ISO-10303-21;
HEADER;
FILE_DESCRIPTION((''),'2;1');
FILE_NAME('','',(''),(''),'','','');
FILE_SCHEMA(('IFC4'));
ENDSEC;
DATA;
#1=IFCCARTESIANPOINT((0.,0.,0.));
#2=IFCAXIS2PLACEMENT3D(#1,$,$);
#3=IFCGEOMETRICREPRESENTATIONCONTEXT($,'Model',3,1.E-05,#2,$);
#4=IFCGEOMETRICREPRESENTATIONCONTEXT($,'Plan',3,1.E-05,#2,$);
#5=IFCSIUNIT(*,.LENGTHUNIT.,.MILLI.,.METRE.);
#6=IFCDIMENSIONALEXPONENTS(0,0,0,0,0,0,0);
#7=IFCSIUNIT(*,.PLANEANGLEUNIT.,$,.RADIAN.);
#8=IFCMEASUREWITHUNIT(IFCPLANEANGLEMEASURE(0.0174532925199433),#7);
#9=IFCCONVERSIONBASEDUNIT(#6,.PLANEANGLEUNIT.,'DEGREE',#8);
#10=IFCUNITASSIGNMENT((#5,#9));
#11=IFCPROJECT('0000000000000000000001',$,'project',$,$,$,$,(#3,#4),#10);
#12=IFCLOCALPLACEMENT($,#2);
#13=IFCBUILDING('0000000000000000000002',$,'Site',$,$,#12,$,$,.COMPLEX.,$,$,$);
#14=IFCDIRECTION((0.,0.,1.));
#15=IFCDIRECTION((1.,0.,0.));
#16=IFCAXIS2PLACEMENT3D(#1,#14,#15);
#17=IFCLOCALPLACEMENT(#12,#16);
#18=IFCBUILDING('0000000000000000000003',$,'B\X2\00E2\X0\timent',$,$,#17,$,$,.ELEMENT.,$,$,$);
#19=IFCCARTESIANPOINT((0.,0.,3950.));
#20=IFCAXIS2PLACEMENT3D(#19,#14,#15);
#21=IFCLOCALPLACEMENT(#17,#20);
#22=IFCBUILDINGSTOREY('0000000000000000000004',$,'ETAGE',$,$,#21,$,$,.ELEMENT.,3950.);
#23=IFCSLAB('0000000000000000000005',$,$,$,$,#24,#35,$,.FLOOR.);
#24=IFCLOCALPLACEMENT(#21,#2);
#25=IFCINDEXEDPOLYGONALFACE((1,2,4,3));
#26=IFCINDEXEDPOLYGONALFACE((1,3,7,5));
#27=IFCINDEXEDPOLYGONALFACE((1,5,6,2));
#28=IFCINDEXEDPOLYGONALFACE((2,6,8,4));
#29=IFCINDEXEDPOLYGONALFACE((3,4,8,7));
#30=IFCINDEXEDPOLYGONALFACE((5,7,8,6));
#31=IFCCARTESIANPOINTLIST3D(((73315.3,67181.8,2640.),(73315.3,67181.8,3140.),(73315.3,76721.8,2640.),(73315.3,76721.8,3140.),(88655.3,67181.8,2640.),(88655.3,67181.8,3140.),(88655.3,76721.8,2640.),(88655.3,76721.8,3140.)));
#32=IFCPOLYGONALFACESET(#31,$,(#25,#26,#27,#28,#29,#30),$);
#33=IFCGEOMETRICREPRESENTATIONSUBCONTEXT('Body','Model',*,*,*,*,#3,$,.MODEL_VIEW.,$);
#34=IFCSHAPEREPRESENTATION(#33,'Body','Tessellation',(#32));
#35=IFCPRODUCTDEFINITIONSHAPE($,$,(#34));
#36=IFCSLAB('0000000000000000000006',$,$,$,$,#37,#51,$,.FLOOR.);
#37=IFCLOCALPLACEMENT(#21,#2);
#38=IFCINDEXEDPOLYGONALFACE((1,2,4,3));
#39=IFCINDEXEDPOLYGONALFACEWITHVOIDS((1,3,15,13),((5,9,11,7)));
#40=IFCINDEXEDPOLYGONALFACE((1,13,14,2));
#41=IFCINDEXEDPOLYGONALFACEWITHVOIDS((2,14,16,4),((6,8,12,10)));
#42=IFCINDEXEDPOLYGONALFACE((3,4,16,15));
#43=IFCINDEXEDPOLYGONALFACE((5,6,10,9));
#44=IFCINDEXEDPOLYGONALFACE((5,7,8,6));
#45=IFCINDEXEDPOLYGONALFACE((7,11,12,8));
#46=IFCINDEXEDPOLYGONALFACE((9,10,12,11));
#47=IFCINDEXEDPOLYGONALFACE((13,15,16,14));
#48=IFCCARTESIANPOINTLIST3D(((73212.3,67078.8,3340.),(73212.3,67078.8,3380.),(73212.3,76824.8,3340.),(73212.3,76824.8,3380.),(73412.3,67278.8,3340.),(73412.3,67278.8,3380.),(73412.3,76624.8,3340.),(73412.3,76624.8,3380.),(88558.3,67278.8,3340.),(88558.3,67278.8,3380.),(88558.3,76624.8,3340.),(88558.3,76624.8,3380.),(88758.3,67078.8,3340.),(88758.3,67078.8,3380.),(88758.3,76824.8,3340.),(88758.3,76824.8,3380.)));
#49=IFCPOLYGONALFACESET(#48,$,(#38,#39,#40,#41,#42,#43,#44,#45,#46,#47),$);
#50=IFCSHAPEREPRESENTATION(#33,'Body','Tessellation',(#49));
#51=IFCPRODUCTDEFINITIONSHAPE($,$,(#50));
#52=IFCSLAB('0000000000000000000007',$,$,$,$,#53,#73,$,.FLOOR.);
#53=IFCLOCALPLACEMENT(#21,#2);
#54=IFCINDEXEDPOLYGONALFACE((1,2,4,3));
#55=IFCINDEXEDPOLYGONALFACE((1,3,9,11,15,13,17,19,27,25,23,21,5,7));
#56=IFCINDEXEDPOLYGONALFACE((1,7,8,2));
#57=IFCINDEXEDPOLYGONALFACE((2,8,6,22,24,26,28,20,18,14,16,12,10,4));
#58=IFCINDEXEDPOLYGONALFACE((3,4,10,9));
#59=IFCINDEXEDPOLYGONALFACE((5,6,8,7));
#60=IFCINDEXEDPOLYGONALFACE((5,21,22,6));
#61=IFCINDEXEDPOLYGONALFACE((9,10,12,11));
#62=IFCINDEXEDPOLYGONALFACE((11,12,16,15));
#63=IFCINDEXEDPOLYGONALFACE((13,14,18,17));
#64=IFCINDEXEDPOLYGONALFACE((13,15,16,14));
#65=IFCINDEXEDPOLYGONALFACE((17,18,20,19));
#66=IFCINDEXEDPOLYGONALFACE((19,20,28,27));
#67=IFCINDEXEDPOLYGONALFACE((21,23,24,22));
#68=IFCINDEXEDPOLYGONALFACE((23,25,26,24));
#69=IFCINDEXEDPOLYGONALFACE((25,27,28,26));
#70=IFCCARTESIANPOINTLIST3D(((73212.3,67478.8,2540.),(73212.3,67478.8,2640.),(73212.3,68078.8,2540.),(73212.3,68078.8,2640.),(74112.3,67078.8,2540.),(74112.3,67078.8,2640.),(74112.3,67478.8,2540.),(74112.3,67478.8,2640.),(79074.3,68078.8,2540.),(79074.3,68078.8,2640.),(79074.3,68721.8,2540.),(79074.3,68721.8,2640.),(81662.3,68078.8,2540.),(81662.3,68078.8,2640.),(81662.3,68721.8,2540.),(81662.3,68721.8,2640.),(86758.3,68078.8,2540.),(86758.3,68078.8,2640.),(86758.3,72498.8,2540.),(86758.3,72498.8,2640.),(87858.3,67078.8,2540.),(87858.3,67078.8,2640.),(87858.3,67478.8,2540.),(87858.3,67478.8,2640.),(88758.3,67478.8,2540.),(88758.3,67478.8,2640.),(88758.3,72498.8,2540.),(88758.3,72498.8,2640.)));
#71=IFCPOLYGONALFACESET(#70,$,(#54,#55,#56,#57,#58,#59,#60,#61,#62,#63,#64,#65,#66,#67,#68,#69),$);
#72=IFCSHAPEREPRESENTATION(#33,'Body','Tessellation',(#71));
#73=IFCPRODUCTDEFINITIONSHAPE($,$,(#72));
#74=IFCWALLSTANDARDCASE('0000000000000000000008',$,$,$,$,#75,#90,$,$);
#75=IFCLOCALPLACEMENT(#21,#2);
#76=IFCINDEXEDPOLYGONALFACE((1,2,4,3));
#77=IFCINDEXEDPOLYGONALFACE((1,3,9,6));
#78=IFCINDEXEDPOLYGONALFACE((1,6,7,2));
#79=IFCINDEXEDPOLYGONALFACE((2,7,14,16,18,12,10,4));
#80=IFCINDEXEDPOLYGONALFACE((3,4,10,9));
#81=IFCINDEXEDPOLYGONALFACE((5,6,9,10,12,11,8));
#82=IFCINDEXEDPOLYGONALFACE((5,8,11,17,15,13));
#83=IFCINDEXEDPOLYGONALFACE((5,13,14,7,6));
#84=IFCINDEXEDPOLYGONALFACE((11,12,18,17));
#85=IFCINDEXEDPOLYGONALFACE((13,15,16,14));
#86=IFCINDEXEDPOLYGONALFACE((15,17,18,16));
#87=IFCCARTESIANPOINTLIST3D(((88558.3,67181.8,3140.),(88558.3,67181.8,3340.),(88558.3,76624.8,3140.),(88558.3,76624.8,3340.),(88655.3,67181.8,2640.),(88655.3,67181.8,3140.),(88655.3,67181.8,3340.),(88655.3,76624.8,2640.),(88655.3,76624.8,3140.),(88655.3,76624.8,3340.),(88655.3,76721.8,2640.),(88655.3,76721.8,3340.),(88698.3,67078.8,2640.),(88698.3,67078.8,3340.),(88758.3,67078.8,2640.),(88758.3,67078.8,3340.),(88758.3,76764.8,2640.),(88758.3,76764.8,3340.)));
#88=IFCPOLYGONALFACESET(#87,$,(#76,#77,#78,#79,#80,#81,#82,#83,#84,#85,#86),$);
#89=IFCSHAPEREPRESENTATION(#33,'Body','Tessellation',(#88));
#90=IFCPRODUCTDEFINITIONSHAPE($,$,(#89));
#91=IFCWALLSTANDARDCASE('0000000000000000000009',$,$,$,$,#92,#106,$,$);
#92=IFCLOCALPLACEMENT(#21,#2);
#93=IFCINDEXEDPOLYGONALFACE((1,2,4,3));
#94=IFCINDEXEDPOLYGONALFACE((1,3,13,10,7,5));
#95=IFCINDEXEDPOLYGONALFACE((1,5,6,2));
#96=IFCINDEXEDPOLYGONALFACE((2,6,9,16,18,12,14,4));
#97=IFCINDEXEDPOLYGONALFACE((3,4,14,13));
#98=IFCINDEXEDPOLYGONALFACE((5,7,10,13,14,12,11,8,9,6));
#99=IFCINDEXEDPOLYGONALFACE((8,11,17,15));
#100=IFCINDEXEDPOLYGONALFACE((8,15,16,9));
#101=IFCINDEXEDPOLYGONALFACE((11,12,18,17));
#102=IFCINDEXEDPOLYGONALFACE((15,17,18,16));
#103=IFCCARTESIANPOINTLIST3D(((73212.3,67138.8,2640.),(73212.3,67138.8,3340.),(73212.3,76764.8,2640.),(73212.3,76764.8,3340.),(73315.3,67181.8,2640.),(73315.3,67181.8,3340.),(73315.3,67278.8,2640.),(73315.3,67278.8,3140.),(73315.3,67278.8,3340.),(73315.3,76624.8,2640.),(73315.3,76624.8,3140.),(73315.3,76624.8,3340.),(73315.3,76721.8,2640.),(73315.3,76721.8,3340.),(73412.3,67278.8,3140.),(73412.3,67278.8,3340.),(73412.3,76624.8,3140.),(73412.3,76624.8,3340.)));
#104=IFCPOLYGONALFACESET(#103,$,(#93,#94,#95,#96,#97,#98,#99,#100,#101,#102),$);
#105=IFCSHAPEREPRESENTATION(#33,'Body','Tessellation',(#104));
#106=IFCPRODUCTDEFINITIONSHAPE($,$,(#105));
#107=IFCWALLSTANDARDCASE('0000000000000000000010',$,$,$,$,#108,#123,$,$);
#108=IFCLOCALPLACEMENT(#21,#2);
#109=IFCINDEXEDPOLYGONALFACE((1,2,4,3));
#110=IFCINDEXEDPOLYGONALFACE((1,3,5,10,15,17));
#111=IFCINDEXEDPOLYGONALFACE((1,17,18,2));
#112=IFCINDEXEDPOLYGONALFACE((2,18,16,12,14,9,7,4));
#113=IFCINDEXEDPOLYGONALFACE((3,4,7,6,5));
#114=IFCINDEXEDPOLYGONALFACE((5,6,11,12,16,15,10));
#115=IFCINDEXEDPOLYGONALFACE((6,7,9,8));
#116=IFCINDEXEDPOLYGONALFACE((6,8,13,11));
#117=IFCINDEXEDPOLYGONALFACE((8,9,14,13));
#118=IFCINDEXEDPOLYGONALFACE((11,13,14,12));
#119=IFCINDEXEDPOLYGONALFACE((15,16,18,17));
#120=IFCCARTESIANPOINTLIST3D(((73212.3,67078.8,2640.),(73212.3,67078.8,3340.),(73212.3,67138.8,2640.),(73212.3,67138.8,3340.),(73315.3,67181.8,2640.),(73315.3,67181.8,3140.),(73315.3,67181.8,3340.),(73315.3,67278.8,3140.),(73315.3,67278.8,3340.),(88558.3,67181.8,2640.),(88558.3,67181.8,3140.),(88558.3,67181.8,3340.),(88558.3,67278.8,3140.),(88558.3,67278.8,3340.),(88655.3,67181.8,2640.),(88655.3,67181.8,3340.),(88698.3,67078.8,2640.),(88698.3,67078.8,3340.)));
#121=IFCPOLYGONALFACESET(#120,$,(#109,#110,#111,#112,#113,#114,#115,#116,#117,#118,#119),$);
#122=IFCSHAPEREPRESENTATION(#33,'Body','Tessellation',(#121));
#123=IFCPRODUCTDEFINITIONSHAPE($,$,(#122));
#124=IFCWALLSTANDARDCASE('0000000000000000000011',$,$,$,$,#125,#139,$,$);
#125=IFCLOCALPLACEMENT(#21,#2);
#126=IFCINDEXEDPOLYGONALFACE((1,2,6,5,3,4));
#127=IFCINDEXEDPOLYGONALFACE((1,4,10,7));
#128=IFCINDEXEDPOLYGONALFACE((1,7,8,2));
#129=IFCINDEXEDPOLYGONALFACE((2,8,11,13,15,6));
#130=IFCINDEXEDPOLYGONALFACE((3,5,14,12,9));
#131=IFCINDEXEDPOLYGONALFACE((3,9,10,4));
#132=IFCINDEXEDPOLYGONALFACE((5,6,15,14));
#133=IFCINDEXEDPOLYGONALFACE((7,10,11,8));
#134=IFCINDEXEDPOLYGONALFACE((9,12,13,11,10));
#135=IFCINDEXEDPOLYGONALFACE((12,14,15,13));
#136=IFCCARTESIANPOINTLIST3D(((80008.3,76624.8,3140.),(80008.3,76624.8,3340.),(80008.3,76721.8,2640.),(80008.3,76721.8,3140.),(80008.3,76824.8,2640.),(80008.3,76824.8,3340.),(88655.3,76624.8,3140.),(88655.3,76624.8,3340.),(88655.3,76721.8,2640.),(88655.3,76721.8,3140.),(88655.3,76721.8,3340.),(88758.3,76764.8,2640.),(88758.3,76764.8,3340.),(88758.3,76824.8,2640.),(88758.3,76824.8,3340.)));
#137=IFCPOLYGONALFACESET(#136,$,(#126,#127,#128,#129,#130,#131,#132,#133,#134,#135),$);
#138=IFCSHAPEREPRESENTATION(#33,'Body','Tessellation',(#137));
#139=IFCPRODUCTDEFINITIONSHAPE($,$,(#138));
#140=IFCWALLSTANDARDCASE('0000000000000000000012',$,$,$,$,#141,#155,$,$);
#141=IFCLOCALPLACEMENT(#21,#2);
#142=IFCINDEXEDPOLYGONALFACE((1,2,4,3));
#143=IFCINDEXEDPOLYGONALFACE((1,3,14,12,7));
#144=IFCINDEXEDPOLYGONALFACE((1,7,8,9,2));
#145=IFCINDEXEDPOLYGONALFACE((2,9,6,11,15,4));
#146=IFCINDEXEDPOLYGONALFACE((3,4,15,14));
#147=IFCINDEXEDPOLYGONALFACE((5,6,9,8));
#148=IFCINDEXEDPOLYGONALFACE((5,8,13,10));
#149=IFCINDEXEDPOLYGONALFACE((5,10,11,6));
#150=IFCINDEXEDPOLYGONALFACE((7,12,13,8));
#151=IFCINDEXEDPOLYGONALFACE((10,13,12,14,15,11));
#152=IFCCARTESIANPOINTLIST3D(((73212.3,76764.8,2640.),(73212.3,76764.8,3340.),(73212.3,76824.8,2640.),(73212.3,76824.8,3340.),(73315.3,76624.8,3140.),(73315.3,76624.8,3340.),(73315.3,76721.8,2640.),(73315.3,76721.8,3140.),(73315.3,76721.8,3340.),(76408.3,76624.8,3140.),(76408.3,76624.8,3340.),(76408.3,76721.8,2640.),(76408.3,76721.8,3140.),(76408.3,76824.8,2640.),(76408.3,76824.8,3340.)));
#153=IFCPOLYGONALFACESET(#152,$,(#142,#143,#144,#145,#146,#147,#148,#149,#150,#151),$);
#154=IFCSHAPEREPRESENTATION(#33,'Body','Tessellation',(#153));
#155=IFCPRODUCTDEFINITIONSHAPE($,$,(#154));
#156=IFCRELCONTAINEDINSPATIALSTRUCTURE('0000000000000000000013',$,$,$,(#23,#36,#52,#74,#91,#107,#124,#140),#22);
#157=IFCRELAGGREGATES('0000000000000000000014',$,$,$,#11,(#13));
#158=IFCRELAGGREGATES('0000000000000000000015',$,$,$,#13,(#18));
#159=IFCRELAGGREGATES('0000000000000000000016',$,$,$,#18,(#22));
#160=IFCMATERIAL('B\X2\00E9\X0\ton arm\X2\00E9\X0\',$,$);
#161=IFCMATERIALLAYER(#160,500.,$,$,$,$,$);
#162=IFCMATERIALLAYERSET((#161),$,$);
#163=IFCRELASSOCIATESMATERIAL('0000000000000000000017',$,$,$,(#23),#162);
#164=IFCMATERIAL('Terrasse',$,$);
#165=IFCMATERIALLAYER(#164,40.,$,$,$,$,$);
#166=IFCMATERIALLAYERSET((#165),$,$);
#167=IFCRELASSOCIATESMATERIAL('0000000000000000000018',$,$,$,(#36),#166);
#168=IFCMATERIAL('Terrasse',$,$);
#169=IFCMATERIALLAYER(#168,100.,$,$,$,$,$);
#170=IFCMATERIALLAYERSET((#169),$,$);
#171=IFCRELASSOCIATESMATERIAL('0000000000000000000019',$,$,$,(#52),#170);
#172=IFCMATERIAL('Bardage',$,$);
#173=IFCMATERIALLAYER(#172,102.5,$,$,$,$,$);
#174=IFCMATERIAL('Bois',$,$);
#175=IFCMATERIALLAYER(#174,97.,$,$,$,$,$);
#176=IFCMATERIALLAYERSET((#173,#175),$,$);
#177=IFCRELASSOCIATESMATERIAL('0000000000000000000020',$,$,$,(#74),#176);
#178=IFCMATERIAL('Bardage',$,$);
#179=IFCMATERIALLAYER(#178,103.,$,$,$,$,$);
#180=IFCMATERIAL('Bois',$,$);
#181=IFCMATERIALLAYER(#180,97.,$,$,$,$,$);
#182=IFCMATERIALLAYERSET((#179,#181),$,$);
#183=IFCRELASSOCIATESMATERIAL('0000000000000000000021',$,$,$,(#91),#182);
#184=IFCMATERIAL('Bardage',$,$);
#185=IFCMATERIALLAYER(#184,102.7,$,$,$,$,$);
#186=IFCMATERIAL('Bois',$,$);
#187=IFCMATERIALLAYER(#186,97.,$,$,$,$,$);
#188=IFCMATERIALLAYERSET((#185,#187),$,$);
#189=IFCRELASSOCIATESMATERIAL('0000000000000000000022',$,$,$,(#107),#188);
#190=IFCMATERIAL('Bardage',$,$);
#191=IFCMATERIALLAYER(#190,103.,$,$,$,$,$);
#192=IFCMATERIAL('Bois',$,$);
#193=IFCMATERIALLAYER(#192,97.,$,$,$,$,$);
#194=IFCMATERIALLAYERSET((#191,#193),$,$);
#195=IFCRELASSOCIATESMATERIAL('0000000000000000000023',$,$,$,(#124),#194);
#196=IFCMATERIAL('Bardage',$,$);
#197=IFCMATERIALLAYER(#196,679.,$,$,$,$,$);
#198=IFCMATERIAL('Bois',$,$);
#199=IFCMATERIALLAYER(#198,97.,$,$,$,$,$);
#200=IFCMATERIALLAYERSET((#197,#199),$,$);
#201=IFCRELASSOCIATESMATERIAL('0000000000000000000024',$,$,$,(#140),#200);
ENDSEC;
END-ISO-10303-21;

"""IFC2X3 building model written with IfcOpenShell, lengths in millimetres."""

from ifc_helpers import new_model, entity, si_unit, converted_unit, frame, frame_2d, origin, origin_with_axes, place, context, subcontext, project, spatial, polyline, rectangle, outline, extrude, clip, bounded_halfspace, material, layer, layer_set, layer_usage, element, save


model = new_model("IFC2X3")

# Units and contexts
model_context = context("Model", 3, precision=1e-05, world=origin())
plan_context = context("Plan", 3, precision=1e-05, world=origin())
body_context = subcontext(model_context, "Body", "Model", "MODEL_VIEW")
ifc_project = project(units=[si_unit("LENGTHUNIT", "METRE", prefix="MILLI"), converted_unit("PLANEANGLEUNIT", "DEGREE", entity("IfcPlaneAngleMeasure", 0.0174532925199433), si_unit("PLANEANGLEUNIT", "RADIAN"), dimensions=[0, 0, 0, 0, 0, 0, 0])], contexts=[model_context, plan_context])

# Buildings, storey
building_1_placement = place(None, origin())
building_1 = spatial("IfcBuilding", under=ifc_project, at=building_1_placement, Name="Site", CompositionType="COMPLEX")
building_2_placement = place(building_1_placement, origin_with_axes())
building_2 = spatial("IfcBuilding", under=building_1, at=building_2_placement, Name="Bâtiment", CompositionType="ELEMENT")
storey_placement = place(building_2_placement, frame((0.0, 0.0, 3950.0), z_axis=(0.0, 0.0, 1.0), x_axis=(1.0, 0.0, 0.0)))
storey = spatial("IfcBuildingStorey", under=building_2, at=storey_placement, Name="ETAGE", CompositionType="ELEMENT", Elevation=3950.0)

# Slabs
ifc_material_1 = material(Name="Béton armé")
ifc_layer_1 = layer(ifc_material_1, 500.0)
ifc_layer_set_1 = layer_set([ifc_layer_1])
ifc_layer_usage_1 = layer_usage(ifc_layer_set_1, "AXIS3", "POSITIVE", 0.0)
slab_1_placement = place(storey_placement, frame((73315.3, 76721.8, 2640.0), z_axis=(0.0, 0.0, 1.0), x_axis=(1.0, 0.0, 0.0)))
element("IfcSlab", 1, at=slab_1_placement, inside=storey, material=ifc_layer_usage_1, PredefinedType="FLOOR", context=body_context, shape_type="SweptSolid", body=[
    extrude(rectangle(XDim=9540.0, YDim=15340.0, at=frame_2d((7670.0, -4770.0), x_axis=(0.0, -1.0))), origin_with_axes(), (0.0, 0.0, 1.0), 500.0),
])
ifc_material_2 = material(Name="Terrasse")
ifc_layer_2 = layer(ifc_material_2, 40.0)
ifc_layer_set_2 = layer_set([ifc_layer_2])
ifc_layer_usage_2 = layer_usage(ifc_layer_set_2, "AXIS3", "POSITIVE", 0.0)
slab_2_placement = place(storey_placement, frame((73212.3, 67078.8, 3340.0), z_axis=(0.0, 0.0, 1.0), x_axis=(1.0, 0.0, 0.0)))
element("IfcSlab", 2, at=slab_2_placement, inside=storey, material=ifc_layer_usage_2, PredefinedType="FLOOR", context=body_context, shape_type="SweptSolid", body=[
    extrude(outline(polyline([(0.0, 9746.0), (0.0, 0.0), (15546.0, 0.0), (15546.0, 9746.0), (0.0, 9746.0)]), holes=[polyline([(15346.0, 200.0), (200.0, 200.0), (200.0, 9546.0), (15346.0, 9546.0), (15346.0, 200.0)])]), origin_with_axes(), (0.0, 0.0, 1.0), 40.0),
])
ifc_material_3 = material(Name="Terrasse")
ifc_layer_3 = layer(ifc_material_3, 100.0)
ifc_layer_set_3 = layer_set([ifc_layer_3])
ifc_layer_usage_3 = layer_usage(ifc_layer_set_3, "AXIS3", "POSITIVE", 0.0)
slab_3_placement = place(storey_placement, frame((73212.3, 67078.8, 2540.0), z_axis=(0.0, 0.0, 1.0), x_axis=(1.0, 0.0, 0.0)))
element("IfcSlab", 3, at=slab_3_placement, inside=storey, material=ifc_layer_usage_3, PredefinedType="FLOOR", context=body_context, shape_type="SweptSolid", body=[
    extrude(outline(polyline([(900.0, 0.0), (14646.0, 0.0), (14646.0, 400.0), (15546.0, 400.0), (15546.0, 5420.0), (13546.0, 5420.0), (13546.0, 1000.0), (8450.0, 1000.0), (8450.0, 1643.0), (5862.0, 1643.0), (5862.0, 1000.0), (0.0, 1000.0), (0.0, 400.0), (900.0, 400.0), (900.0, 0.0)])), origin_with_axes(), (0.0, 0.0, 1.0), 100.0),
])

# Walls
ifc_material_4 = material(Name="Bardage")
ifc_layer_4 = layer(ifc_material_4, 102.5)
ifc_material_5 = material(Name="Bois")
ifc_layer_5 = layer(ifc_material_5, 97.0)
ifc_layer_set_4 = layer_set([ifc_layer_4, ifc_layer_5])
ifc_layer_usage_4 = layer_usage(ifc_layer_set_4, "AXIS2", "POSITIVE", 0.0)
wall_1_placement = place(storey_placement, frame((88758.3, 67078.8, 2640.0), z_axis=(0.0, 0.0, 1.0), x_axis=(0.0, 1.0, 0.0)))
element("IfcWallStandardCase", 4, at=wall_1_placement, inside=storey, material=ifc_layer_usage_4, context=body_context, shape_type="Clipping", body=[
    clip(clip(extrude(outline(polyline([(0.0, 60.0), (0.0, 0.0), (9686.0, 0.0), (9643.0, 103.0), (9546.0, 103.0), (9546.0, 200.0), (103.0, 200.0), (103.0, 103.0), (0.0, 60.0)])), origin_with_axes(), (0.0, 0.0, 1.0), 700.0), bounded_halfspace(frame((0.0, 60.0, 0.0), z_axis=(0.0, 0.0, 1.0), x_axis=(0.0, -1.0, 0.0)), True, origin(), polyline([(0.0, 60.0), (0.0, 0.0), (9686.0, 0.0), (9643.0, 103.0), (103.0, 103.0), (0.0, 60.0)]))), bounded_halfspace(frame((103.0, 200.0, 500.0), z_axis=(0.0, 0.0, 1.0), x_axis=(0.0, -1.0, 0.0)), True, origin(), polyline([(103.0, 200.0), (103.0, 103.0), (9546.0, 103.0), (9546.0, 200.0), (103.0, 200.0)]))),
])
ifc_material_6 = material(Name="Bardage")
ifc_layer_6 = layer(ifc_material_6, 103.0)
ifc_material_7 = material(Name="Bois")
ifc_layer_7 = layer(ifc_material_7, 97.0)
ifc_layer_set_5 = layer_set([ifc_layer_6, ifc_layer_7])
ifc_layer_usage_5 = layer_usage(ifc_layer_set_5, "AXIS2", "POSITIVE", 0.0)
wall_2_placement = place(storey_placement, frame((73212.3, 76764.8, 2640.0), z_axis=(0.0, 0.0, 1.0), x_axis=(0.0, -1.0, 0.0)))
element("IfcWallStandardCase", 5, at=wall_2_placement, inside=storey, material=ifc_layer_usage_5, context=body_context, shape_type="Clipping", body=[
    clip(clip(extrude(outline(polyline([(0.0, 0.0), (9626.0, 0.0), (9583.0, 103.0), (9486.0, 103.0), (9486.0, 200.0), (140.0, 200.0), (140.0, 103.0), (43.0, 103.0), (0.0, 0.0)])), origin_with_axes(), (0.0, 0.0, 1.0), 700.0), bounded_halfspace(frame((43.0, 103.0, 0.0), z_axis=(0.0, 0.0, 1.0), x_axis=(-0.385251, -0.922812, 0.0)), True, origin(), polyline([(43.0, 103.0), (0.0, 0.0), (9626.0, 0.0), (9583.0, 103.0), (43.0, 103.0)]))), bounded_halfspace(frame((140.0, 200.0, 500.0), z_axis=(0.0, 0.0, 1.0), x_axis=(0.0, -1.0, 0.0)), True, origin(), polyline([(140.0, 200.0), (140.0, 103.0), (9486.0, 103.0), (9486.0, 200.0), (140.0, 200.0)]))),
])
ifc_material_8 = material(Name="Bardage")
ifc_layer_8 = layer(ifc_material_8, 102.7)
ifc_material_9 = material(Name="Bois")
ifc_layer_9 = layer(ifc_material_9, 97.0)
ifc_layer_set_6 = layer_set([ifc_layer_8, ifc_layer_9])
ifc_layer_usage_6 = layer_usage(ifc_layer_set_6, "AXIS2", "POSITIVE", 0.0)
wall_3_placement = place(storey_placement, frame((73212.3, 67078.8, 2640.0), z_axis=(0.0, 0.0, 1.0), x_axis=(1.0, 0.0, 0.0)))
element("IfcWallStandardCase", 6, at=wall_3_placement, inside=storey, material=ifc_layer_usage_6, context=body_context, shape_type="Clipping", body=[
    clip(clip(extrude(outline(polyline([(0.0, 60.0), (0.0, 0.0), (15486.0, 0.0), (15443.0, 103.0), (15346.0, 103.0), (15346.0, 200.0), (103.0, 200.0), (103.0, 103.0), (0.0, 60.0)])), origin_with_axes(), (0.0, 0.0, 1.0), 700.0), bounded_halfspace(frame((0.0, 60.0, 0.0), z_axis=(0.0, 0.0, 1.0), x_axis=(0.0, -1.0, 0.0)), True, origin(), polyline([(0.0, 60.0), (0.0, 0.0), (15486.0, 0.0), (15443.0, 103.0), (103.0, 103.0), (0.0, 60.0)]))), bounded_halfspace(frame((103.0, 200.0, 500.0), z_axis=(0.0, 0.0, 1.0), x_axis=(0.0, -1.0, 0.0)), True, origin(), polyline([(103.0, 200.0), (103.0, 103.0), (15346.0, 103.0), (15346.0, 200.0), (103.0, 200.0)]))),
])
ifc_material_10 = material(Name="Bardage")
ifc_layer_10 = layer(ifc_material_10, 103.0)
ifc_material_11 = material(Name="Bois")
ifc_layer_11 = layer(ifc_material_11, 97.0)
ifc_layer_set_7 = layer_set([ifc_layer_10, ifc_layer_11])
ifc_layer_usage_7 = layer_usage(ifc_layer_set_7, "AXIS2", "POSITIVE", 0.0)
wall_4_placement = place(storey_placement, frame((88758.3, 76824.8, 2640.0), z_axis=(0.0, 0.0, 1.0), x_axis=(-1.0, 0.0, 0.0)))
element("IfcWallStandardCase", 7, at=wall_4_placement, inside=storey, material=ifc_layer_usage_7, context=body_context, shape_type="Clipping", body=[
    clip(clip(extrude(outline(polyline([(0.0, 0.0), (8750.0, 0.0), (8750.0, 200.0), (103.0, 200.0), (103.0, 103.0), (0.0, 60.0), (0.0, 0.0)])), origin_with_axes(), (0.0, 0.0, 1.0), 700.0), bounded_halfspace(frame((0.0, 60.0, 0.0), z_axis=(0.0, 0.0, 1.0), x_axis=(0.0, -1.0, 0.0)), True, origin(), polyline([(0.0, 60.0), (0.0, 0.0), (8750.0, 0.0), (8750.0, 103.0), (103.0, 103.0), (0.0, 60.0)]))), bounded_halfspace(frame((103.0, 200.0, 500.0), z_axis=(0.0, 0.0, 1.0), x_axis=(0.0, -1.0, 0.0)), True, origin(), polyline([(103.0, 200.0), (103.0, 103.0), (8750.0, 103.0), (8750.0, 200.0), (103.0, 200.0)]))),
])
ifc_material_12 = material(Name="Bardage")
ifc_layer_12 = layer(ifc_material_12, 679.0)
ifc_material_13 = material(Name="Bois")
ifc_layer_13 = layer(ifc_material_13, 97.0)
ifc_layer_set_8 = layer_set([ifc_layer_12, ifc_layer_13])
ifc_layer_usage_8 = layer_usage(ifc_layer_set_8, "AXIS2", "POSITIVE", 0.0)
wall_5_placement = place(storey_placement, frame((76408.3, 76824.8, 2640.0), z_axis=(0.0, 0.0, 1.0), x_axis=(-1.0, 0.0, 0.0)))
element("IfcWallStandardCase", 8, at=wall_5_placement, inside=storey, material=ifc_layer_usage_8, context=body_context, shape_type="Clipping", body=[
    clip(clip(extrude(outline(polyline([(0.0, 0.0), (3196.0, 0.0), (3196.0, 60.0), (3093.0, 103.0), (3093.0, 200.0), (0.0, 200.0), (0.0, 0.0)])), origin_with_axes(), (0.0, 0.0, 1.0), 700.0), bounded_halfspace(frame((0.0, 103.0, 0.0), z_axis=(0.0, 0.0, 1.0), x_axis=(0.0, -1.0, 0.0)), True, origin(), polyline([(0.0, 103.0), (0.0, 0.0), (3196.0, 0.0), (3196.0, 60.0), (3093.0, 103.0), (0.0, 103.0)]))), bounded_halfspace(frame((0.0, 200.0, 500.0), z_axis=(0.0, 0.0, 1.0), x_axis=(0.0, -1.0, 0.0)), True, origin(), polyline([(0.0, 200.0), (0.0, 103.0), (3093.0, 103.0), (3093.0, 200.0), (0.0, 200.0)]))),
])

save(model, "model.ifc")
